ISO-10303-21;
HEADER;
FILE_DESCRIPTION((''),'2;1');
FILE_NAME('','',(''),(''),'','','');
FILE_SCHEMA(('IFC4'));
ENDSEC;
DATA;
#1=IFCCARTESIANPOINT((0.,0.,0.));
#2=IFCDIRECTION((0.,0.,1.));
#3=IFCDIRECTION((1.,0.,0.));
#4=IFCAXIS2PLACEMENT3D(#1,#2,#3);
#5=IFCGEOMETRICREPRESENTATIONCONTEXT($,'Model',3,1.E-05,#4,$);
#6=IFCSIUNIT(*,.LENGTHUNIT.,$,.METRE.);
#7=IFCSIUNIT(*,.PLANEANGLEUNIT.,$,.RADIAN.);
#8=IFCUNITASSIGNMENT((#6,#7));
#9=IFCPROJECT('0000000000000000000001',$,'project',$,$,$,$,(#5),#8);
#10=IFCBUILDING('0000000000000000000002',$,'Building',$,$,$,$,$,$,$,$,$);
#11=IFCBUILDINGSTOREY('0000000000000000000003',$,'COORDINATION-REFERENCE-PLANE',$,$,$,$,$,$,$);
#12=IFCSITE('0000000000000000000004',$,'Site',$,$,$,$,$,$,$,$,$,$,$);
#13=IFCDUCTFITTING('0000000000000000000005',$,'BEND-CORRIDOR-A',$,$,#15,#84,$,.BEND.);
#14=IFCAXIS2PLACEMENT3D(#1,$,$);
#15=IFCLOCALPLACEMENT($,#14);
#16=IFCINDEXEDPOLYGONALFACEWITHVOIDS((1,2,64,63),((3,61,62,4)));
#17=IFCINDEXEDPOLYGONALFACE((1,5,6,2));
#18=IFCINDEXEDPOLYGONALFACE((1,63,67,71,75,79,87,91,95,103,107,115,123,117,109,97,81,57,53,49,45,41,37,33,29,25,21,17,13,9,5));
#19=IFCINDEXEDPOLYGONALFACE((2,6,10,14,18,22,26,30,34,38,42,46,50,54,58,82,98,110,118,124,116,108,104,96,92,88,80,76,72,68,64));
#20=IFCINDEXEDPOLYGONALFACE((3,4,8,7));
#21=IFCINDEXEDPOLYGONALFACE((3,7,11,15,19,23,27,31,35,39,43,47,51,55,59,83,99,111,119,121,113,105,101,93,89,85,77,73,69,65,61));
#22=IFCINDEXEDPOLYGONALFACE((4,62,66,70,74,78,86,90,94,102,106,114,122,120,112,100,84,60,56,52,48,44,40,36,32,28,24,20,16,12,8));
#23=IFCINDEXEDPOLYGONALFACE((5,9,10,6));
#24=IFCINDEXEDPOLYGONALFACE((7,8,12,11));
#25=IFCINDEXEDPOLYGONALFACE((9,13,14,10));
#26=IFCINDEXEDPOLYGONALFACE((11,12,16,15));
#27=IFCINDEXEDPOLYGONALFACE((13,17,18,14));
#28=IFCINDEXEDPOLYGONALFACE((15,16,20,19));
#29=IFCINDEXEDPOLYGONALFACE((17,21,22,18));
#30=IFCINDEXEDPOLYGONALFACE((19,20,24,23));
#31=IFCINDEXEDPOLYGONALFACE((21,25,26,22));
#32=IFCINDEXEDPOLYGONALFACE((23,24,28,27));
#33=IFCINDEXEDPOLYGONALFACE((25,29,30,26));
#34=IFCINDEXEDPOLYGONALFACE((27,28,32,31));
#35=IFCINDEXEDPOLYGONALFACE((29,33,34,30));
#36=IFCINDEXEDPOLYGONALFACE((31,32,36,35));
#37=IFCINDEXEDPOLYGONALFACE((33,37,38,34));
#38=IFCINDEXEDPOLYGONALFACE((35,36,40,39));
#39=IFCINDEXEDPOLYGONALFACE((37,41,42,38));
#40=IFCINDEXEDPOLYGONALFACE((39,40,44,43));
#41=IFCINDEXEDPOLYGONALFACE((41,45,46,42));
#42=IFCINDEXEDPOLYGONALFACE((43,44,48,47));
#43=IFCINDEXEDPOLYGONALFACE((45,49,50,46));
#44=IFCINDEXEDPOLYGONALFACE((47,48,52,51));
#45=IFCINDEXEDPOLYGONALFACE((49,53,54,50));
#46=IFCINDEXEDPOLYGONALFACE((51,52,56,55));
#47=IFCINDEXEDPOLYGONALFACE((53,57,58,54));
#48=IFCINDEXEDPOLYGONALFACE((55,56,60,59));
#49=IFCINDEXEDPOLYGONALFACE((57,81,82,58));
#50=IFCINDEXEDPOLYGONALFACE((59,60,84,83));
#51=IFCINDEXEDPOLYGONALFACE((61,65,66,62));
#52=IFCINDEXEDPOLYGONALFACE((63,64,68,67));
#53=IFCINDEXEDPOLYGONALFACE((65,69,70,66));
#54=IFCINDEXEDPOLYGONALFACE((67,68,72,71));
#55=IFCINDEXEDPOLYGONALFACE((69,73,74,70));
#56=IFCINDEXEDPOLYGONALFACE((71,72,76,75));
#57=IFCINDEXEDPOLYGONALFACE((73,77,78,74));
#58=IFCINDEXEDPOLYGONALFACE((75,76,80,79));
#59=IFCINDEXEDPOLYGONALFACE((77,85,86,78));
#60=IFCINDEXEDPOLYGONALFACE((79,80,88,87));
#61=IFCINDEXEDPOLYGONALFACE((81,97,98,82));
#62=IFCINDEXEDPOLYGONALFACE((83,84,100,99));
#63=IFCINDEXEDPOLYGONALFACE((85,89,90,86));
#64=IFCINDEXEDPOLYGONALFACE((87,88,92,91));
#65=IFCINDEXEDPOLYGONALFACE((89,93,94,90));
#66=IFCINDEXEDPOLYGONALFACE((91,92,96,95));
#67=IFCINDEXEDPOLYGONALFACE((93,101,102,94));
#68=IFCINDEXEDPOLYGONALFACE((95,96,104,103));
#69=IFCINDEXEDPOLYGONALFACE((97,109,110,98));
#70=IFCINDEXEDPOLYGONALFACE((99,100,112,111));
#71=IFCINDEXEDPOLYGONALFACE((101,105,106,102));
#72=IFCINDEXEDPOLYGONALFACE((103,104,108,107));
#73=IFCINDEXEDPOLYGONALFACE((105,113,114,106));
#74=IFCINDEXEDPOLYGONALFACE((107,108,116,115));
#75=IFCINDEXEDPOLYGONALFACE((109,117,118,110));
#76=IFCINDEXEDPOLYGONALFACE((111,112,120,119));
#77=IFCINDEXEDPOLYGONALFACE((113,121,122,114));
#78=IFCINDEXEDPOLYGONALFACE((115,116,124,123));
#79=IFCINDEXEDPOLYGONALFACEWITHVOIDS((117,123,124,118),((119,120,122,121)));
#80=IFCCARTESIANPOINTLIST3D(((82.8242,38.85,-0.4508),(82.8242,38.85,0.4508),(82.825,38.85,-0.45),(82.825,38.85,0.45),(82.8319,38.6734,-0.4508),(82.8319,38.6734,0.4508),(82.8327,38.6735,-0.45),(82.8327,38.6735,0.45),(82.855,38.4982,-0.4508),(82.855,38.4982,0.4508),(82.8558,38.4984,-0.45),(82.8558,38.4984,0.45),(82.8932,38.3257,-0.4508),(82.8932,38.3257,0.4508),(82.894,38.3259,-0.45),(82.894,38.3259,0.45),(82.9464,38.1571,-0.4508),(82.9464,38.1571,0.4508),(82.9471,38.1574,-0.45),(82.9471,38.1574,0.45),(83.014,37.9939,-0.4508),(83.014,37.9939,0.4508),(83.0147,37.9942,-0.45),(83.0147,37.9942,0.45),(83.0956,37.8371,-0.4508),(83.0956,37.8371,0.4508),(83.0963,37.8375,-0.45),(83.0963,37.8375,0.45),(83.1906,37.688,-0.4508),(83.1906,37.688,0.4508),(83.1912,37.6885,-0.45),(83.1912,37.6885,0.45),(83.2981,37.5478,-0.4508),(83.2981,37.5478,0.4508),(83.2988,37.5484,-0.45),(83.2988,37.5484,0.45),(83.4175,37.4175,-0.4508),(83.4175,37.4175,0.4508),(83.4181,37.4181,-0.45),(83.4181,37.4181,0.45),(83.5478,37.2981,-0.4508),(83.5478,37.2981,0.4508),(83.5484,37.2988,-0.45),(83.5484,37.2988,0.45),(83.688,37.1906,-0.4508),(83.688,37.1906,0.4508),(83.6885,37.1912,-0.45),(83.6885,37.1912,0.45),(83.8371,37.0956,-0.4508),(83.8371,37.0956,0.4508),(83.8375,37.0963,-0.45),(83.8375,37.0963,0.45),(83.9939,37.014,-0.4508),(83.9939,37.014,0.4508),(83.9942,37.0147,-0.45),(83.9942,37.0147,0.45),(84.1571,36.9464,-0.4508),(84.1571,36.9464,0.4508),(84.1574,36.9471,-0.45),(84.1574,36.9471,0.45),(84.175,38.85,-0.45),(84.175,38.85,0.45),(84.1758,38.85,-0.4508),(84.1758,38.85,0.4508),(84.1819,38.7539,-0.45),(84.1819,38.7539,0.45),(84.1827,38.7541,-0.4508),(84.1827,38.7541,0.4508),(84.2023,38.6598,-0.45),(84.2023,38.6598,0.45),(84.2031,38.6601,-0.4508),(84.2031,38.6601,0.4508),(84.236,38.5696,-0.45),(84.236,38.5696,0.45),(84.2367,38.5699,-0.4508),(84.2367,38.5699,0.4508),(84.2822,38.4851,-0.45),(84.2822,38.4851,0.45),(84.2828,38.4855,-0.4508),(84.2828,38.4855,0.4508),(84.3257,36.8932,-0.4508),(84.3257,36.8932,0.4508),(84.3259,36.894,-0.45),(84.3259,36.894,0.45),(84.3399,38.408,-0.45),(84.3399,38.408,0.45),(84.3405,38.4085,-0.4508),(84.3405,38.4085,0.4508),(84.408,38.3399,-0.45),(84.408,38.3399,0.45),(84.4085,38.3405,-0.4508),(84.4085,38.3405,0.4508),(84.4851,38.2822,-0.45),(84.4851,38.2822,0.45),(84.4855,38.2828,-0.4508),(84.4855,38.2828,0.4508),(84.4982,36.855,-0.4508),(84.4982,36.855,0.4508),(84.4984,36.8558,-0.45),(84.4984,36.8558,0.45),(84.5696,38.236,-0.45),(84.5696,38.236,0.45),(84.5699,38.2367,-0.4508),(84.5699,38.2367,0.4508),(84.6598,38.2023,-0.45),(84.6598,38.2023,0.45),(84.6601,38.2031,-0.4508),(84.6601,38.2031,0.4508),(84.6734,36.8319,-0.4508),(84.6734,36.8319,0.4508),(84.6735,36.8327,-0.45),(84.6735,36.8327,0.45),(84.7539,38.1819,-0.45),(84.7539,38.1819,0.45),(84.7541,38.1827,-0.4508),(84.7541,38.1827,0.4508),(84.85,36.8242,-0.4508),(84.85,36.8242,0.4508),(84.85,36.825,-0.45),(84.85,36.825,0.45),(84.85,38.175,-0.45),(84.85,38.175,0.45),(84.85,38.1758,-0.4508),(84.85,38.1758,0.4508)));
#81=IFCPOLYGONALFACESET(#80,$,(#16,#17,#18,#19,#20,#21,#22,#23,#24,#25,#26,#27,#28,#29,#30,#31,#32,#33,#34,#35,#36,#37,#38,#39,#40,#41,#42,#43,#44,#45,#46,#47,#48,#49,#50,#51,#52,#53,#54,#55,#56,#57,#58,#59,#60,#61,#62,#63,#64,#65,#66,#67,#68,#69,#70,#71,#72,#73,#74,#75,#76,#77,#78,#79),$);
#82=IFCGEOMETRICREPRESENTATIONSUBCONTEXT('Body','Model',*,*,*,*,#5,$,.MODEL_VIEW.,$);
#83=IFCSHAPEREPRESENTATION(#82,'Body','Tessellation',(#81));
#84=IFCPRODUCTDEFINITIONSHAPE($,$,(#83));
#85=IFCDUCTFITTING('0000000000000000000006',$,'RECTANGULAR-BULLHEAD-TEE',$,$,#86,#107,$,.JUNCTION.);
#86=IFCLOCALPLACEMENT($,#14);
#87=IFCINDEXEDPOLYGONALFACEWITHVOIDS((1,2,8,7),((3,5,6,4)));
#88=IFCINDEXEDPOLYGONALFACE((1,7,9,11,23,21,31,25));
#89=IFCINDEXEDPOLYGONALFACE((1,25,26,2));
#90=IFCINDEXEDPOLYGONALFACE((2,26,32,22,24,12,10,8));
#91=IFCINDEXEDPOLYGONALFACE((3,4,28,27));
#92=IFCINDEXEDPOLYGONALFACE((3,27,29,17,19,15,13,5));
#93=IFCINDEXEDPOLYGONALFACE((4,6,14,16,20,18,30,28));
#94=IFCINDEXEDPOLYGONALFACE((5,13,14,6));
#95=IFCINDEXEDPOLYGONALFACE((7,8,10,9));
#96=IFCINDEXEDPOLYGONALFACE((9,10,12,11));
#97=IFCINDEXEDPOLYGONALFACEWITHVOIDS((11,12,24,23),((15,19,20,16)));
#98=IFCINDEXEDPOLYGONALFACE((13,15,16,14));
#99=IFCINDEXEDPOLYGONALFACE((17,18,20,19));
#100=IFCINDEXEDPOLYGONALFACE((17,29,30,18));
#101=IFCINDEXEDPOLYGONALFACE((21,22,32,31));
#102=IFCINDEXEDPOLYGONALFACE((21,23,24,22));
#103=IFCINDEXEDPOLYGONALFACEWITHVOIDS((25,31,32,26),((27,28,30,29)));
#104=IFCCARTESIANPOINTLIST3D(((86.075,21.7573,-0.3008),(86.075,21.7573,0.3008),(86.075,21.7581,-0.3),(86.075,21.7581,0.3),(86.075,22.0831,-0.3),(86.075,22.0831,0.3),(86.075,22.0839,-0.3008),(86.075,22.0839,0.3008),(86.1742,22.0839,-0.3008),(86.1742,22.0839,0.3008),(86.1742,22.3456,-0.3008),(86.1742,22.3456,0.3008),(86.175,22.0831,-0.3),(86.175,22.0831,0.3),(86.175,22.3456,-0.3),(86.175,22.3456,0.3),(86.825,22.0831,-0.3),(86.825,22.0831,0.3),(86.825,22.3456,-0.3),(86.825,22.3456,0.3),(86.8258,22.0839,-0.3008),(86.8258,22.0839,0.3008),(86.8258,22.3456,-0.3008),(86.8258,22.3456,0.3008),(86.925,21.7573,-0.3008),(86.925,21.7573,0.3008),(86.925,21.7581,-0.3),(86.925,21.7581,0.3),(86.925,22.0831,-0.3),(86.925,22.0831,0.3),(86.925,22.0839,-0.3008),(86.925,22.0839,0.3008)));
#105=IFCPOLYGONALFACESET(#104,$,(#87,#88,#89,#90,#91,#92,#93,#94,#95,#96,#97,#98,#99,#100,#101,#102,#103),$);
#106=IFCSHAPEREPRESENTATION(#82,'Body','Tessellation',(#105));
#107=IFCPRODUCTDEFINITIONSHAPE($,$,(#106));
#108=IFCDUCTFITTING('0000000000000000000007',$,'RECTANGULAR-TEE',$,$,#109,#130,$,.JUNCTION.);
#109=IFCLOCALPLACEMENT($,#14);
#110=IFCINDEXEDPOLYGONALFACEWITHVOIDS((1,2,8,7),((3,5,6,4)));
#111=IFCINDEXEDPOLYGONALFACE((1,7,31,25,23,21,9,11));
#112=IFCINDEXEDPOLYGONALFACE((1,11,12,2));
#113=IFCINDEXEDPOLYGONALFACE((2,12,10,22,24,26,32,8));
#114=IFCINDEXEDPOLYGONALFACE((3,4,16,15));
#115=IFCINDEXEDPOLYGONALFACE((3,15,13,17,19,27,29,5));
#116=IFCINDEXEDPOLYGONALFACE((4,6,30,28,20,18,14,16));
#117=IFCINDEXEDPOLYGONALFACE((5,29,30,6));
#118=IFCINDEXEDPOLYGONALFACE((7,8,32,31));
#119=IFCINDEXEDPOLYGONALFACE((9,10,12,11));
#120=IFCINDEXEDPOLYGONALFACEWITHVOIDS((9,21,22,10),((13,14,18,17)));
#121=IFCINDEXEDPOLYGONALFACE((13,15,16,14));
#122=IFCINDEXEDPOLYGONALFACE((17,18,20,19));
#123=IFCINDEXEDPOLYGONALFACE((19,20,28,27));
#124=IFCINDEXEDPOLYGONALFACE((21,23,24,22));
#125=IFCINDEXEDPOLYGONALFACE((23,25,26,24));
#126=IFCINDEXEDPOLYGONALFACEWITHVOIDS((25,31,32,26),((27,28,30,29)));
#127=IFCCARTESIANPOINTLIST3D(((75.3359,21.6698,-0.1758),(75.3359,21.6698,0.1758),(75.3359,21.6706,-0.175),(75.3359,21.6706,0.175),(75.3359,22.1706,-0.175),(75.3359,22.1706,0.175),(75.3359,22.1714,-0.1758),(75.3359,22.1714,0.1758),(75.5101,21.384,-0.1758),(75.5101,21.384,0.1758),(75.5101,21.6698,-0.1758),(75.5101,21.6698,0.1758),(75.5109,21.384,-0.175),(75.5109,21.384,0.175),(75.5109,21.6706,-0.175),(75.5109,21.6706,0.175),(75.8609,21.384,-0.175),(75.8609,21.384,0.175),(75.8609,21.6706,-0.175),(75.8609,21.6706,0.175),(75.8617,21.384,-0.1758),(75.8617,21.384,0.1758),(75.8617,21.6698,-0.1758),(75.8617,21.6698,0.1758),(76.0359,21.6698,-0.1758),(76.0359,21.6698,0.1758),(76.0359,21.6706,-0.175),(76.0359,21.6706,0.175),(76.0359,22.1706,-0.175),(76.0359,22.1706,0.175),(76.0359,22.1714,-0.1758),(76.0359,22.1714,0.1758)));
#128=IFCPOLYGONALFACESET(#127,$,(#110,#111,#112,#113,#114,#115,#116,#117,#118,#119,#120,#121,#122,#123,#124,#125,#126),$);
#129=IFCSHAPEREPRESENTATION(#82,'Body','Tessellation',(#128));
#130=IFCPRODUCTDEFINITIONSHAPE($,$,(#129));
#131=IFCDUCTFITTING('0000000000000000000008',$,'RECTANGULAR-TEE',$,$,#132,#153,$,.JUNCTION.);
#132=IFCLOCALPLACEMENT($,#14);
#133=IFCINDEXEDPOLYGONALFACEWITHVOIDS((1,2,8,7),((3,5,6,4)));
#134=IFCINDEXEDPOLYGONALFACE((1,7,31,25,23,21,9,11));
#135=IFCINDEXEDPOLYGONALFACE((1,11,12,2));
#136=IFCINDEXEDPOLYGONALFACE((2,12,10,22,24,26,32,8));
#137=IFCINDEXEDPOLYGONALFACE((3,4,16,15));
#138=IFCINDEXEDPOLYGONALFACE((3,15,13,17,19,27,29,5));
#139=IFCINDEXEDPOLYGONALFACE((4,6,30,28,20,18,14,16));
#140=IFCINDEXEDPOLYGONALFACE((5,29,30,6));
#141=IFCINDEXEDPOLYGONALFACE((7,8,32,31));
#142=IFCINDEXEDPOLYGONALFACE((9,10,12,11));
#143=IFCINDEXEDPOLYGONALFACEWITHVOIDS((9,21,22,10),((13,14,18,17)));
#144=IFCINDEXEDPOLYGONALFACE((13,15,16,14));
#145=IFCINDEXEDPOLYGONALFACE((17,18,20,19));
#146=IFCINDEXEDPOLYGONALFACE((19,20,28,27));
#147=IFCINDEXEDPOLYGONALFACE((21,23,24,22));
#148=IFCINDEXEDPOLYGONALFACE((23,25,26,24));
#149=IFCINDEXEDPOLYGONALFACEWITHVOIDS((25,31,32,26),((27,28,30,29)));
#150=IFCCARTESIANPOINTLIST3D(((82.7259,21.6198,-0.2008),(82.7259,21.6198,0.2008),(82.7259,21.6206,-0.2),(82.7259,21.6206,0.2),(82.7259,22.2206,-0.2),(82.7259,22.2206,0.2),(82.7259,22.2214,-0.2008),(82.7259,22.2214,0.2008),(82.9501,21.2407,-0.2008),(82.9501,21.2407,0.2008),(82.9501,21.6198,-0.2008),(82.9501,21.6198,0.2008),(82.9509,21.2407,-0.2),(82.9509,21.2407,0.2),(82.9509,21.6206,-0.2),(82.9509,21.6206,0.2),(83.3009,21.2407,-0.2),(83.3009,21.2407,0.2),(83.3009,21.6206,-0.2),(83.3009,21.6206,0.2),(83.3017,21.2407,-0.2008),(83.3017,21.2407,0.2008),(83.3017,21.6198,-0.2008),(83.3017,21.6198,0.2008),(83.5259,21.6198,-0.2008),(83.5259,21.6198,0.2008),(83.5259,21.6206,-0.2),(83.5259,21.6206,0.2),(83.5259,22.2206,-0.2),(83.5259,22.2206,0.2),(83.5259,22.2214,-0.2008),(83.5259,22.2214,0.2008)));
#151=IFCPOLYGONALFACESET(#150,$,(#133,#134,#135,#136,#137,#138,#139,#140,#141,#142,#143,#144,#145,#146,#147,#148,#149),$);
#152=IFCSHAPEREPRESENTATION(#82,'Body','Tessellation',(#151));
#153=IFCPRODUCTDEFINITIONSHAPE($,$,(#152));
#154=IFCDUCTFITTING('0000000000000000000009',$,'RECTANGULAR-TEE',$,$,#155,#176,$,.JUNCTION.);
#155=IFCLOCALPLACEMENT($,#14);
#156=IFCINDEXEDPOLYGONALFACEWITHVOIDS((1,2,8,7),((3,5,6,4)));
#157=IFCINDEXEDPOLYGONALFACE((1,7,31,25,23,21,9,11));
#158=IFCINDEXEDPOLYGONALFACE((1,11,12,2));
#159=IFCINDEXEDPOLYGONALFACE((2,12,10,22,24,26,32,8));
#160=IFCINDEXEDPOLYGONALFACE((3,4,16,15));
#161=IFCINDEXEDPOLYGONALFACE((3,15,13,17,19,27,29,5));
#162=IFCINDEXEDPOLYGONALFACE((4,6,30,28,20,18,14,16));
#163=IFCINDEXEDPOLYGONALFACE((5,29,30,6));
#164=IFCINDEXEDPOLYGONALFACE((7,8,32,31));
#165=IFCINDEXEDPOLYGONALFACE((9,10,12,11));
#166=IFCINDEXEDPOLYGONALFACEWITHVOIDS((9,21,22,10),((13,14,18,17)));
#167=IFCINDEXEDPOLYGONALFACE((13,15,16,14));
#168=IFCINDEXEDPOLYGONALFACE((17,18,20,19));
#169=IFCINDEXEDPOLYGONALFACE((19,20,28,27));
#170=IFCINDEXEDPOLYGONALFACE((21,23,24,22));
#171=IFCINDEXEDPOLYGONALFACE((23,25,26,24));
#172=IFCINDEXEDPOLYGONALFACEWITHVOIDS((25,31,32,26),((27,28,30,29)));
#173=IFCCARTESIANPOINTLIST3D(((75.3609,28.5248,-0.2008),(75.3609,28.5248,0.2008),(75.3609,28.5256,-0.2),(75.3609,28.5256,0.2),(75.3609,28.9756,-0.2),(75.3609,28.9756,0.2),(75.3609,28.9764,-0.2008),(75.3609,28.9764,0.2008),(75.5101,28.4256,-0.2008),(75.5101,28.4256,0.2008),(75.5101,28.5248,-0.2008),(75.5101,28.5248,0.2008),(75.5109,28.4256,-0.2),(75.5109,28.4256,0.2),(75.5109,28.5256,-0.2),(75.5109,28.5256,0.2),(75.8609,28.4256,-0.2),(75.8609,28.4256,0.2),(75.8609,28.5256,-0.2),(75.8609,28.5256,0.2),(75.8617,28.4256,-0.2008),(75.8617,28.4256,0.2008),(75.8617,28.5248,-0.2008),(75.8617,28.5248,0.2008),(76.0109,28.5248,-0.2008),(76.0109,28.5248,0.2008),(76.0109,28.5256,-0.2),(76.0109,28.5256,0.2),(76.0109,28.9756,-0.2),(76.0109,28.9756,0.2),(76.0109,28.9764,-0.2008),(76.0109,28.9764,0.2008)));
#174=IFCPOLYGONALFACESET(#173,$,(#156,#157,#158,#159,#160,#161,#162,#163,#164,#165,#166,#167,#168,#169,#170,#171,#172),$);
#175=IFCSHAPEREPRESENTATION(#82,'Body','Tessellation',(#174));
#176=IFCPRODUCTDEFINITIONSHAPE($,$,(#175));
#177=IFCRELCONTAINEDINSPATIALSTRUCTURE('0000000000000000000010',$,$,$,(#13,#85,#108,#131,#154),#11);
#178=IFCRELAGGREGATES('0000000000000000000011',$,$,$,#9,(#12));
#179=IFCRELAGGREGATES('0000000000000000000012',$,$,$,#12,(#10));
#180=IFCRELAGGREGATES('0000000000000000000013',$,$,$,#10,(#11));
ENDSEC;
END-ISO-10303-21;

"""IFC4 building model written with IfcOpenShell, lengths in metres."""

from ifc_helpers import new_model, entity, si_unit, frame, origin_with_axes, place, context, subcontext, project, spatial, rectangle, extrude, boolean, element, save


model = new_model("IFC4")

# Units and contexts
model_context = context("Model", 3, precision=1e-05, world=origin_with_axes())
body_context = subcontext(model_context, "Body", "Model", "MODEL_VIEW")
ifc_project = project(units=[si_unit("LENGTHUNIT", "METRE"), si_unit("PLANEANGLEUNIT", "RADIAN")], contexts=[model_context])

# Site, building, storey
site = spatial("IfcSite", under=ifc_project, Name="Site")
building = spatial("IfcBuilding", under=site, Name="Building")
storey = spatial("IfcBuildingStorey", under=building, Name="COORDINATION-REFERENCE-PLANE")

# Duct fittings
duct_fitting_1_placement = place(None, frame((84.85, 38.85, 0.0), z_axis=(0.0, 0.0, 1.0), x_axis=(-1.0, 0.0, 0.0)))
cartesian_point_1 = entity("IfcCartesianPoint", [0.0, 0.0, 0.0])
element("IfcDuctFitting", 1, at=duct_fitting_1_placement, inside=storey, Name="BEND-CORRIDOR-A", PredefinedType="BEND", context=body_context, shape_type="SweptSolid", body=[
    entity("IfcRevolvedAreaSolid", entity("IfcRectangleHollowProfileDef", "AREA", None, entity("IfcAxis2Placement2D", entity("IfcCartesianPoint", [1.35, 0.0])), 1.3516, 0.9016, 0.0008), entity("IfcAxis2Placement3D", cartesian_point_1, entity("IfcDirection", [0.0, -1.0, 0.0]), entity("IfcDirection", [1.0, 0.0, 0.0])), entity("IfcAxis1Placement", cartesian_point_1, entity("IfcDirection", [0.0, 1.0, 0.0])), 1.570796),
])
duct_fitting_2_placement = place(None, frame((86.5, 21.9206, 0.0), z_axis=(1.0, 0.0, 0.0), x_axis=(0.0, 1.0, 0.0)))
solid_1 = boolean("UNION", extrude(rectangle(XDim=0.325, YDim=0.6), frame((0.0, 0.0, -0.425), z_axis=(0.0, 0.0, 1.0), x_axis=(1.0, 0.0, 0.0)), (0.0, 0.0, 1.0), 0.85), extrude(rectangle(XDim=0.65, YDim=0.6), frame((0.0, 0.0, 0.0), z_axis=(1.0, 0.0, 0.0), x_axis=(0.0, 0.0, -1.0)), (0.0, 0.0, 1.0), 0.425))
element("IfcDuctFitting", 2, at=duct_fitting_2_placement, inside=storey, Name="RECTANGULAR-BULLHEAD-TEE", PredefinedType="JUNCTION", context=body_context, shape_type="CSG", body=[
    boolean("DIFFERENCE", boolean("UNION", extrude(rectangle(XDim=0.3266, YDim=0.6016), frame((0.0, 0.0, -0.425), z_axis=(0.0, 0.0, 1.0), x_axis=(1.0, 0.0, 0.0)), (0.0, 0.0, 1.0), 0.85), extrude(rectangle(XDim=0.6516, YDim=0.6016), frame((0.0, 0.0, 0.0), z_axis=(1.0, 0.0, 0.0), x_axis=(0.0, 0.0, -1.0)), (0.0, 0.0, 1.0), 0.425)), solid_1),
])
duct_fitting_3_placement = place(None, frame((75.6859, 21.9206, 0.0), z_axis=(-1.0, 0.0, 0.0), x_axis=(0.0, -1.0, 0.0)))
solid_2 = boolean("UNION", extrude(rectangle(XDim=0.5, YDim=0.35), frame((0.0, 0.0, -0.35), z_axis=(0.0, 0.0, 1.0), x_axis=(1.0, 0.0, 0.0)), (0.0, 0.0, 1.0), 0.7), extrude(rectangle(XDim=0.35, YDim=0.35), frame((0.0, 0.0, 0.0), z_axis=(1.0, 0.0, 0.0), x_axis=(0.0, 0.0, -1.0)), (0.0, 0.0, 1.0), 0.5366))
element("IfcDuctFitting", 3, at=duct_fitting_3_placement, inside=storey, Name="RECTANGULAR-TEE", PredefinedType="JUNCTION", context=body_context, shape_type="CSG", body=[
    boolean("DIFFERENCE", boolean("UNION", extrude(rectangle(XDim=0.5016, YDim=0.3516), frame((0.0, 0.0, -0.35), z_axis=(0.0, 0.0, 1.0), x_axis=(1.0, 0.0, 0.0)), (0.0, 0.0, 1.0), 0.7), extrude(rectangle(XDim=0.3516, YDim=0.3516), frame((0.0, 0.0, 0.0), z_axis=(1.0, 0.0, 0.0), x_axis=(0.0, 0.0, -1.0)), (0.0, 0.0, 1.0), 0.5366)), solid_2),
])
duct_fitting_4_placement = place(None, frame((83.1259, 21.9206, 0.0), z_axis=(-1.0, 0.0, 0.0), x_axis=(0.0, -1.0, 0.0)))
solid_3 = boolean("UNION", extrude(rectangle(XDim=0.6, YDim=0.4), frame((0.0, 0.0, -0.4), z_axis=(0.0, 0.0, 1.0), x_axis=(1.0, 0.0, 0.0)), (0.0, 0.0, 1.0), 0.8), extrude(rectangle(XDim=0.35, YDim=0.4), frame((0.0, 0.0, 0.0), z_axis=(1.0, 0.0, 0.0), x_axis=(0.0, 0.0, -1.0)), (0.0, 0.0, 1.0), 0.6799))
element("IfcDuctFitting", 4, at=duct_fitting_4_placement, inside=storey, Name="RECTANGULAR-TEE", PredefinedType="JUNCTION", context=body_context, shape_type="CSG", body=[
    boolean("DIFFERENCE", boolean("UNION", extrude(rectangle(XDim=0.6016, YDim=0.4016), frame((0.0, 0.0, -0.4), z_axis=(0.0, 0.0, 1.0), x_axis=(1.0, 0.0, 0.0)), (0.0, 0.0, 1.0), 0.8), extrude(rectangle(XDim=0.3516, YDim=0.4016), frame((0.0, 0.0, 0.0), z_axis=(1.0, 0.0, 0.0), x_axis=(0.0, 0.0, -1.0)), (0.0, 0.0, 1.0), 0.6799)), solid_3),
])
duct_fitting_5_placement = place(None, frame((75.6859, 28.7506, 0.0), z_axis=(-1.0, 0.0, 0.0), x_axis=(0.0, -1.0, 0.0)))
solid_4 = boolean("UNION", extrude(rectangle(XDim=0.45, YDim=0.4), frame((0.0, 0.0, -0.325), z_axis=(0.0, 0.0, 1.0), x_axis=(1.0, 0.0, 0.0)), (0.0, 0.0, 1.0), 0.65), extrude(rectangle(XDim=0.35, YDim=0.4), frame((0.0, 0.0, 0.0), z_axis=(1.0, 0.0, 0.0), x_axis=(0.0, 0.0, -1.0)), (0.0, 0.0, 1.0), 0.325))
element("IfcDuctFitting", 5, at=duct_fitting_5_placement, inside=storey, Name="RECTANGULAR-TEE", PredefinedType="JUNCTION", context=body_context, shape_type="CSG", body=[
    boolean("DIFFERENCE", boolean("UNION", extrude(rectangle(XDim=0.4516, YDim=0.4016), frame((0.0, 0.0, -0.325), z_axis=(0.0, 0.0, 1.0), x_axis=(1.0, 0.0, 0.0)), (0.0, 0.0, 1.0), 0.65), extrude(rectangle(XDim=0.3516, YDim=0.4016), frame((0.0, 0.0, 0.0), z_axis=(1.0, 0.0, 0.0), x_axis=(0.0, 0.0, -1.0)), (0.0, 0.0, 1.0), 0.325)), solid_4),
])

save(model, "model.ifc")
